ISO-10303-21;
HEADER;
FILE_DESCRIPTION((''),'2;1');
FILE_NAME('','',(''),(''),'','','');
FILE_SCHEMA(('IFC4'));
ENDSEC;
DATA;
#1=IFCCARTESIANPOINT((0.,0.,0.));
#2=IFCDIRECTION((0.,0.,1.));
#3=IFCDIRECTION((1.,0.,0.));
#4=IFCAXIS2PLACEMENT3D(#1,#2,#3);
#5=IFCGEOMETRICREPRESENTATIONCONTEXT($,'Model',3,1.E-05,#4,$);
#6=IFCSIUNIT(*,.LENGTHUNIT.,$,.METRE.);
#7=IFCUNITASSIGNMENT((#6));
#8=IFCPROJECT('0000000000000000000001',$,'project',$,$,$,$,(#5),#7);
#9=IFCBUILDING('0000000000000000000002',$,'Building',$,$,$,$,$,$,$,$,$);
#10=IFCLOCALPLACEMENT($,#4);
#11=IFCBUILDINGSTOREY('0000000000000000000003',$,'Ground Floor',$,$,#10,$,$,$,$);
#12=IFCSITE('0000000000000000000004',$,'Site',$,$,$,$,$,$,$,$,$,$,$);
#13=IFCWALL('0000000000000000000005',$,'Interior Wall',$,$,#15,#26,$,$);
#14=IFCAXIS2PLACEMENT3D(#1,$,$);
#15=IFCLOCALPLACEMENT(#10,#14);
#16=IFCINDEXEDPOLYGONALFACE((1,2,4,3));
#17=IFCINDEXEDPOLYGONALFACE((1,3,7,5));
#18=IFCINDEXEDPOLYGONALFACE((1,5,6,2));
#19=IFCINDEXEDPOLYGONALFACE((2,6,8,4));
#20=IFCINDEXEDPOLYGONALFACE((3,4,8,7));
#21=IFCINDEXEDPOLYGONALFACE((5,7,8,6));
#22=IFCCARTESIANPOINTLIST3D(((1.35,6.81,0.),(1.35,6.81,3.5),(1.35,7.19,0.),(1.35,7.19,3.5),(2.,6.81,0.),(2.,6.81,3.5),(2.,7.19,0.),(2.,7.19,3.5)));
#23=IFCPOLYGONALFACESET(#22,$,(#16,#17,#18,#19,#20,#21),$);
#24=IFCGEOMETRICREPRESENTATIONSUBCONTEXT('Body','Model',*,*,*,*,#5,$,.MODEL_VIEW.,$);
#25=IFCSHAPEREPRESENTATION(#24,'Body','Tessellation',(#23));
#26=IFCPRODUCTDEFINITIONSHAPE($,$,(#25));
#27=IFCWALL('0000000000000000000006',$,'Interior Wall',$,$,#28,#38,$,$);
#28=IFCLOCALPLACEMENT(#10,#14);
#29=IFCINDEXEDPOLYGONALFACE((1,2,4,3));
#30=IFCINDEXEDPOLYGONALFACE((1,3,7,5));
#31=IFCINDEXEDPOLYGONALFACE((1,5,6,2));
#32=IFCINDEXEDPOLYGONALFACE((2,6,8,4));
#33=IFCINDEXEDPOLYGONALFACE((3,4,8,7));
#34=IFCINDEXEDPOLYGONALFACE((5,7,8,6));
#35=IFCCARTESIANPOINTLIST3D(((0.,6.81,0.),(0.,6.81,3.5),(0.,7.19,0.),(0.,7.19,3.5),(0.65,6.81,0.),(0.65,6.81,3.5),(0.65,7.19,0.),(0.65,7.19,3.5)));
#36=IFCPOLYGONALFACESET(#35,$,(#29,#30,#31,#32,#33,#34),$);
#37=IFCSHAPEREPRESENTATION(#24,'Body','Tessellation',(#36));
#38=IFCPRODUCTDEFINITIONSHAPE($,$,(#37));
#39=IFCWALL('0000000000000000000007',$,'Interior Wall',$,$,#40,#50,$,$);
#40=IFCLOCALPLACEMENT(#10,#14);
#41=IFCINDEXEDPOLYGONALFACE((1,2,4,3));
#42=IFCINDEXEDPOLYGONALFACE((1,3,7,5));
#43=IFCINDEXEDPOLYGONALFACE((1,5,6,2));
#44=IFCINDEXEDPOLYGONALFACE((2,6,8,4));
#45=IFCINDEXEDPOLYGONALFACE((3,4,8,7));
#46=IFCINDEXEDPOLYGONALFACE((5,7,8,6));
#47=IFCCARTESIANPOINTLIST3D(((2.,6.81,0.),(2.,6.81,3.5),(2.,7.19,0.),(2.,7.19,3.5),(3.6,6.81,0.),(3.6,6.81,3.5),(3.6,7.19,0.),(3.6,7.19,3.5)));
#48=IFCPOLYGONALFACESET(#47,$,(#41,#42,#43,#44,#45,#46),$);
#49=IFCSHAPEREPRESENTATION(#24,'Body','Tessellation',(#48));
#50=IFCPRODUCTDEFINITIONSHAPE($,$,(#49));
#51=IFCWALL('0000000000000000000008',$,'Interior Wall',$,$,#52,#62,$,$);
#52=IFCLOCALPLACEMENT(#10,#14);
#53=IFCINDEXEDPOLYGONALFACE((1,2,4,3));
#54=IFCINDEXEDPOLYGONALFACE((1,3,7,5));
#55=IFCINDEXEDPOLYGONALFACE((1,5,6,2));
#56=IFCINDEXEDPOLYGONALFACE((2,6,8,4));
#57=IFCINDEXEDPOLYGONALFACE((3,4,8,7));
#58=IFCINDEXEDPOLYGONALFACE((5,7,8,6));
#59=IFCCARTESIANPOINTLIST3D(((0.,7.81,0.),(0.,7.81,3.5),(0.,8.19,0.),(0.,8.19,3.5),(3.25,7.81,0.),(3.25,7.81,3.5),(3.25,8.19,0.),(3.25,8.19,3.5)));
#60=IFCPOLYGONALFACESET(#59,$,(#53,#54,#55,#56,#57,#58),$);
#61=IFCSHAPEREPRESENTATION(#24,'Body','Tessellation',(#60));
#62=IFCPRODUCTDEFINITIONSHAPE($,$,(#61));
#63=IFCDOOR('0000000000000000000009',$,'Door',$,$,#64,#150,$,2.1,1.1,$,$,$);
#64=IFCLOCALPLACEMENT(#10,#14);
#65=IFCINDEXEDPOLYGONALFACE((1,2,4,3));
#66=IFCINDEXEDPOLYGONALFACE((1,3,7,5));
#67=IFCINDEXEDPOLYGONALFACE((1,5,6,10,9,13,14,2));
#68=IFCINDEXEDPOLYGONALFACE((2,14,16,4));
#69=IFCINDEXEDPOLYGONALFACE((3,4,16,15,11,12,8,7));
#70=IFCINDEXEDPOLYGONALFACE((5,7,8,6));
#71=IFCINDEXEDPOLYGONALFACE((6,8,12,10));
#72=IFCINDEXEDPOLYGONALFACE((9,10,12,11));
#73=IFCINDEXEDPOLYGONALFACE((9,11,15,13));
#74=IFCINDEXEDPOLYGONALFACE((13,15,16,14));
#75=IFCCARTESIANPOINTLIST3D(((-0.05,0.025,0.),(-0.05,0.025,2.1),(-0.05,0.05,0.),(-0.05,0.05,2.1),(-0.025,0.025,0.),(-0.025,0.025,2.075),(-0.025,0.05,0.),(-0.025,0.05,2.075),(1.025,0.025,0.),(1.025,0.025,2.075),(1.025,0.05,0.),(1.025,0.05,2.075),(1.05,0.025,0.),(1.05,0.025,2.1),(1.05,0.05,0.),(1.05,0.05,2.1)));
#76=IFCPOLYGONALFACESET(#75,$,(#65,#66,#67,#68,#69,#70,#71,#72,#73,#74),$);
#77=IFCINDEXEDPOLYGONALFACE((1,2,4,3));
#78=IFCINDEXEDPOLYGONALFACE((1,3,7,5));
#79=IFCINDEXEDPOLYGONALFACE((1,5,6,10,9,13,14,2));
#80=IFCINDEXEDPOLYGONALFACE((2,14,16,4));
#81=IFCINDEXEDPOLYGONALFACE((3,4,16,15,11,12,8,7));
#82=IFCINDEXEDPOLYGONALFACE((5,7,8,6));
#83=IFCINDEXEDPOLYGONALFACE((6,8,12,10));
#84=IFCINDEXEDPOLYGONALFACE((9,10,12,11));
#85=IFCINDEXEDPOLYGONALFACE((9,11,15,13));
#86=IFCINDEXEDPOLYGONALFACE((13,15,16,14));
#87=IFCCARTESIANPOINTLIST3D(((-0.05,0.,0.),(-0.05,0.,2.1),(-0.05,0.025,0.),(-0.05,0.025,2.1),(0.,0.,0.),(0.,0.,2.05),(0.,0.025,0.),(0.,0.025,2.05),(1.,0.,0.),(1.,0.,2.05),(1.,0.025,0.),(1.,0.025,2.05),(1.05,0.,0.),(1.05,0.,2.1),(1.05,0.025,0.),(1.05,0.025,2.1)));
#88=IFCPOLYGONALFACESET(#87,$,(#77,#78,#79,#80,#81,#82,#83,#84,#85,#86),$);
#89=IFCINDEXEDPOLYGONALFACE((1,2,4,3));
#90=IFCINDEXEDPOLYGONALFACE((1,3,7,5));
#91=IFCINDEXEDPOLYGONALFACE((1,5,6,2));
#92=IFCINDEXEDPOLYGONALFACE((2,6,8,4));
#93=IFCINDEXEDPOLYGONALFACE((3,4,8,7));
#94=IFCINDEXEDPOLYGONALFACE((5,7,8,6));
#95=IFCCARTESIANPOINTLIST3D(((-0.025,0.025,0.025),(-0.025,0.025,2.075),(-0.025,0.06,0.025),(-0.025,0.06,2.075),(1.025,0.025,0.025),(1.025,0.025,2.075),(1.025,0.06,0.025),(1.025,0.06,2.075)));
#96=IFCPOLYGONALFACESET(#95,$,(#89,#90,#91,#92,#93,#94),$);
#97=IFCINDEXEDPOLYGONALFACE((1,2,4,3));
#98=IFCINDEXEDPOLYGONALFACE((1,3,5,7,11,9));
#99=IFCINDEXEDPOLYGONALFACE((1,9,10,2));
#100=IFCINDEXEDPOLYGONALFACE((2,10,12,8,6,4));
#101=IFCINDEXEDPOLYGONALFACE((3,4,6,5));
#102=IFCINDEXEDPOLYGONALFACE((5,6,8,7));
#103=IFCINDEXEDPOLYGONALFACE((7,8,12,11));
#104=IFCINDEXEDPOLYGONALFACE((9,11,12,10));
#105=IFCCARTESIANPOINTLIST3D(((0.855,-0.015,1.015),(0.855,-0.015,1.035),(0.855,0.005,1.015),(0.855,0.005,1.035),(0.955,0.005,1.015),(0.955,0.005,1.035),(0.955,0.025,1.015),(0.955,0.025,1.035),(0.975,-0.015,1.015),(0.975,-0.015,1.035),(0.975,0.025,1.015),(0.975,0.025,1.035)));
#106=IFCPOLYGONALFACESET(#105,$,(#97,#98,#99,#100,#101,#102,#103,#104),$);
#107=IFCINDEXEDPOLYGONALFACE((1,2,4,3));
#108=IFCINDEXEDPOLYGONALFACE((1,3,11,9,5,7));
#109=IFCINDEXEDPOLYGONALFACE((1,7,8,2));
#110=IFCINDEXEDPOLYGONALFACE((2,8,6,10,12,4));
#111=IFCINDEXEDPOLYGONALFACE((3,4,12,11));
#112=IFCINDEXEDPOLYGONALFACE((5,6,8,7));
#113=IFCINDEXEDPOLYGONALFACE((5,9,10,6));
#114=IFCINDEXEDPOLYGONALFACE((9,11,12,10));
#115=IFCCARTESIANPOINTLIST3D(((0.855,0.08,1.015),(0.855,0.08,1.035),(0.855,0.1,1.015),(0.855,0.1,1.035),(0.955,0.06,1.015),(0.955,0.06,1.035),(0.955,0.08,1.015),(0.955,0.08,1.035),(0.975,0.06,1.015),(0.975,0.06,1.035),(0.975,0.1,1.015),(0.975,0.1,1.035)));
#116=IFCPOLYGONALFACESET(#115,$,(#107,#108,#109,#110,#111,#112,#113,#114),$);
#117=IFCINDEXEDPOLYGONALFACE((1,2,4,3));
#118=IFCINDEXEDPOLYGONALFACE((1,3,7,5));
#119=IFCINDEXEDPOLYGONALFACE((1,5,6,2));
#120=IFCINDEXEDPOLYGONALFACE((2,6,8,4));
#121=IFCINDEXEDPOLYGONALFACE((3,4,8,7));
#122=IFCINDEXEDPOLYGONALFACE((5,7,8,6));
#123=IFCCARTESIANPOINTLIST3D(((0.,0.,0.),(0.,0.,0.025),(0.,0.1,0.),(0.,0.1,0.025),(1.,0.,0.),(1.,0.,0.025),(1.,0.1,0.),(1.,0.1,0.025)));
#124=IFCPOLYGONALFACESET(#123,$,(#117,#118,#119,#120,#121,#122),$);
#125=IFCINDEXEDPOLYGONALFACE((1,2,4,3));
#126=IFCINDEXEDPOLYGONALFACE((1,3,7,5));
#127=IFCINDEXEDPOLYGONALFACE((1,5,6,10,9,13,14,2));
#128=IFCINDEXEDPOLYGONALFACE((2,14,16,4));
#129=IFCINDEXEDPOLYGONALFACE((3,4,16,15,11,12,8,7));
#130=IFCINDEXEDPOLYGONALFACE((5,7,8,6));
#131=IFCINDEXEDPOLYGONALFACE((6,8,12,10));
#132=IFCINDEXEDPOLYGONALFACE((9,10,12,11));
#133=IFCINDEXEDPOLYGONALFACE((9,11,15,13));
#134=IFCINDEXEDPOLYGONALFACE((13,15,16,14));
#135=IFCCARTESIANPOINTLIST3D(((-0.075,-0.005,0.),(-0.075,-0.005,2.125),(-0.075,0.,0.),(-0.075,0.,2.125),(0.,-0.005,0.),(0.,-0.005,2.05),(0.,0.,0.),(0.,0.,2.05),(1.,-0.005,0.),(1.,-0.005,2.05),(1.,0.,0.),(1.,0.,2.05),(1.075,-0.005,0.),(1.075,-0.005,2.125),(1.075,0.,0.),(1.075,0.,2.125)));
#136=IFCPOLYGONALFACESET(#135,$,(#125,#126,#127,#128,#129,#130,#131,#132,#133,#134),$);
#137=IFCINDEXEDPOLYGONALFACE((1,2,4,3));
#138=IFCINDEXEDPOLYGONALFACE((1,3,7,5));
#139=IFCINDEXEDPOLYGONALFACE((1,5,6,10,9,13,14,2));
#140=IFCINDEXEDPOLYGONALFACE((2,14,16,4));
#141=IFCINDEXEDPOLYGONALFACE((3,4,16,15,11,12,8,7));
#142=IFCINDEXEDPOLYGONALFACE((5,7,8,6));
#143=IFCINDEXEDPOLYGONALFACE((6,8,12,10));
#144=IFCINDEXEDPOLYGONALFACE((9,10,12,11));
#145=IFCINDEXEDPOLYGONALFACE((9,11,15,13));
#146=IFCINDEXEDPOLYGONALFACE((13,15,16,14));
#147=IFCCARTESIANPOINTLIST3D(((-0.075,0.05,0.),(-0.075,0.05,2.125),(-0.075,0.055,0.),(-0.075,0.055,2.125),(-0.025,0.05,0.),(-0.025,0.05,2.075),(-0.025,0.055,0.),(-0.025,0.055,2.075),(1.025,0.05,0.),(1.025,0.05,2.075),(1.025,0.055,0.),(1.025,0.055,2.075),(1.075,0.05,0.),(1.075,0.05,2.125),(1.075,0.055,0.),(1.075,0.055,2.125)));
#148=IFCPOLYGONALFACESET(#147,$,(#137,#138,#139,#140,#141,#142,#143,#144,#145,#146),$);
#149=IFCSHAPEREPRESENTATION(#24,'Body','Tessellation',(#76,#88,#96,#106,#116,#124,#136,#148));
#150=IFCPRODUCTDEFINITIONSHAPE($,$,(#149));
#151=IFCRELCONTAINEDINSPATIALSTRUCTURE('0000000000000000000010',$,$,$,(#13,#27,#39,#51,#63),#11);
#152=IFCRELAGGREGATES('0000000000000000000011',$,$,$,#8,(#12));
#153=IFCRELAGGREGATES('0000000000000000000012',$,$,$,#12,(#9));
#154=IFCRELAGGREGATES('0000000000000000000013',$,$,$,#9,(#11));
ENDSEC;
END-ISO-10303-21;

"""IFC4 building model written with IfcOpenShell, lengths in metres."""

from ifc_helpers import new_model, si_unit, frame, origin_with_axes, place, context, subcontext, project, spatial, line, indexed_curve, outline, extrude, element, save


model = new_model("IFC4")

# Units and contexts
model_context = context("Model", 3, precision=1e-05, world=origin_with_axes())
body_context = subcontext(model_context, "Body", "Model", "MODEL_VIEW")
ifc_project = project(units=[si_unit("LENGTHUNIT", "METRE")], contexts=[model_context])

# Site, building, storey
site = spatial("IfcSite", under=ifc_project, Name="Site")
building = spatial("IfcBuilding", under=site, Name="Building")
storey_placement = place(None, origin_with_axes())
storey = spatial("IfcBuildingStorey", under=building, at=storey_placement, Name="Ground Floor")

# Walls
for number, where, z_axis, x_axis, name in (
    (1, (2.0, 7.0, 0.0), (0.0, 0.0, 1.0), (-1.0, 0.0, 0.0), "Interior Wall"),
    (2, (0.65, 7.0, 0.0), (0.0, 0.0, 1.0), (-1.0, 0.0, 0.0), "Interior Wall"),
):
    element("IfcWall", number, at=place(storey_placement, frame(where, z_axis=z_axis, x_axis=x_axis)), inside=storey, Name=name, context=body_context, shape_type="SweptSolid", body=[
        extrude(outline(indexed_curve([(0.0, 0.0), (0.0, 0.38), (0.65, 0.38), (0.65, 0.0), (0.0, 0.0)], self_intersect=False)), frame((0.0, -0.19, 0.0), z_axis=(0.0, 0.0, 1.0), x_axis=(1.0, 0.0, 0.0)), (0.0, 0.0, 1.0), 3.5),
    ])
wall_1_placement = place(storey_placement, frame((3.6, 7.0, 0.0), z_axis=(0.0, 0.0, 1.0), x_axis=(-1.0, 0.0, 0.0)))
element("IfcWall", 3, at=wall_1_placement, inside=storey, Name="Interior Wall", context=body_context, shape_type="SweptSolid", body=[
    extrude(outline(indexed_curve([(0.0, 0.0), (0.0, 0.38), (1.6, 0.38), (1.6, 0.0), (0.0, 0.0)], self_intersect=False)), frame((0.0, -0.19, 0.0), z_axis=(0.0, 0.0, 1.0), x_axis=(1.0, 0.0, 0.0)), (0.0, 0.0, 1.0), 3.5),
])
wall_2_placement = place(storey_placement, frame((0.0, 8.0, 0.0), z_axis=(0.0, 0.0, 1.0), x_axis=(1.0, 0.0, 0.0)))
element("IfcWall", 4, at=wall_2_placement, inside=storey, Name="Interior Wall", context=body_context, shape_type="SweptSolid", body=[
    extrude(outline(indexed_curve([(0.0, 0.0), (0.0, 0.38), (3.25, 0.38), (3.25, 0.0), (0.0, 0.0)], self_intersect=False)), frame((0.0, -0.19, 0.0), z_axis=(0.0, 0.0, 1.0), x_axis=(1.0, 0.0, 0.0)), (0.0, 0.0, 1.0), 3.5),
])

# Door
door_1_placement = place(storey_placement, frame((-0.05, 0.0, 0.0), z_axis=(0.0, 0.0, 1.0), x_axis=(1.0, 0.0, 0.0)))
element("IfcDoor", 5, at=door_1_placement, inside=storey, Name="Door", OverallHeight=2.1, OverallWidth=1.1, context=body_context, shape_type="SweptSolid", body=[
    extrude(outline(indexed_curve([(0.0, 0.0), (0.0, 2.1), (1.1, 2.1), (1.1, 0.0), (1.075, 0.0), (1.075, 2.075), (0.025, 2.075), (0.025, 0.0)], segments=[line(1, 2, 3, 4, 5, 6, 7, 8, 1)])), frame((0.0, 0.025, 0.0), z_axis=(0.0, -1.0, 0.0), x_axis=(1.0, 0.0, 0.0)), (0.0, 0.0, -1.0), 0.025),
    extrude(outline(indexed_curve([(0.0, 0.0), (0.0, 2.1), (1.1, 2.1), (1.1, 0.0), (1.05, 0.0), (1.05, 2.05), (0.05, 2.05), (0.05, 0.0)], segments=[line(1, 2, 3, 4, 5, 6, 7, 8, 1)])), frame((0.0, 0.0, 0.0), z_axis=(0.0, -1.0, 0.0), x_axis=(1.0, 0.0, 0.0)), (0.0, 0.0, -1.0), 0.025),
    extrude(outline(indexed_curve([(0.0, 0.0), (1.05, 0.0), (1.05, 0.035), (0.0, 0.035)], segments=[line(1, 2, 3, 4, 1)])), frame((0.025, 0.025, 0.025), z_axis=(0.0, 0.0, 1.0), x_axis=(1.0, 0.0, 0.0)), (0.0, 0.0, 1.0), 2.05),
    extrude(outline(indexed_curve([(0.0, 0.0), (0.0, -0.04), (-0.12, -0.04), (-0.12, -0.02), (-0.02, -0.02), (-0.02, 0.0)], segments=[line(1, 2, 3, 4, 5, 6, 1)])), frame((1.025, 0.025, 1.015), z_axis=(0.0, 0.0, 1.0), x_axis=(1.0, 0.0, 0.0)), (0.0, 0.0, 1.0), 0.02),
    extrude(outline(indexed_curve([(0.0, 0.0), (0.0, 0.04), (-0.12, 0.04), (-0.12, 0.02), (-0.02, 0.02), (-0.02, 0.0)], segments=[line(1, 2, 3, 4, 5, 6, 1)])), frame((1.025, 0.06, 1.015), z_axis=(0.0, 0.0, 1.0), x_axis=(1.0, 0.0, 0.0)), (0.0, 0.0, 1.0), 0.02),
    extrude(outline(indexed_curve([(0.0, 0.0), (1.0, 0.0), (1.0, 0.1), (0.0, 0.1)], segments=[line(1, 2, 3, 4, 1)])), frame((0.05, 0.0, 0.0), z_axis=(0.0, 0.0, 1.0), x_axis=(1.0, 0.0, 0.0)), (0.0, 0.0, 1.0), 0.025),
    extrude(outline(indexed_curve([(0.0, 0.0), (0.0, 2.125), (1.15, 2.125), (1.15, 0.0), (1.075, 0.0), (1.075, 2.05), (0.075, 2.05), (0.075, 0.0)], segments=[line(1, 2, 3, 4, 5, 6, 7, 8, 1)])), frame((-0.025, -0.005, 0.0), z_axis=(0.0, -1.0, 0.0), x_axis=(1.0, 0.0, 0.0)), (0.0, 0.0, -1.0), 0.005),
    extrude(outline(indexed_curve([(0.0, 0.0), (0.0, 2.125), (1.15, 2.125), (1.15, 0.0), (1.1, 0.0), (1.1, 2.075), (0.05, 2.075), (0.05, 0.0)], segments=[line(1, 2, 3, 4, 5, 6, 7, 8, 1)])), frame((-0.025, 0.05, 0.0), z_axis=(0.0, -1.0, 0.0), x_axis=(1.0, 0.0, 0.0)), (0.0, 0.0, -1.0), 0.005),
])

save(model, "model.ifc")
